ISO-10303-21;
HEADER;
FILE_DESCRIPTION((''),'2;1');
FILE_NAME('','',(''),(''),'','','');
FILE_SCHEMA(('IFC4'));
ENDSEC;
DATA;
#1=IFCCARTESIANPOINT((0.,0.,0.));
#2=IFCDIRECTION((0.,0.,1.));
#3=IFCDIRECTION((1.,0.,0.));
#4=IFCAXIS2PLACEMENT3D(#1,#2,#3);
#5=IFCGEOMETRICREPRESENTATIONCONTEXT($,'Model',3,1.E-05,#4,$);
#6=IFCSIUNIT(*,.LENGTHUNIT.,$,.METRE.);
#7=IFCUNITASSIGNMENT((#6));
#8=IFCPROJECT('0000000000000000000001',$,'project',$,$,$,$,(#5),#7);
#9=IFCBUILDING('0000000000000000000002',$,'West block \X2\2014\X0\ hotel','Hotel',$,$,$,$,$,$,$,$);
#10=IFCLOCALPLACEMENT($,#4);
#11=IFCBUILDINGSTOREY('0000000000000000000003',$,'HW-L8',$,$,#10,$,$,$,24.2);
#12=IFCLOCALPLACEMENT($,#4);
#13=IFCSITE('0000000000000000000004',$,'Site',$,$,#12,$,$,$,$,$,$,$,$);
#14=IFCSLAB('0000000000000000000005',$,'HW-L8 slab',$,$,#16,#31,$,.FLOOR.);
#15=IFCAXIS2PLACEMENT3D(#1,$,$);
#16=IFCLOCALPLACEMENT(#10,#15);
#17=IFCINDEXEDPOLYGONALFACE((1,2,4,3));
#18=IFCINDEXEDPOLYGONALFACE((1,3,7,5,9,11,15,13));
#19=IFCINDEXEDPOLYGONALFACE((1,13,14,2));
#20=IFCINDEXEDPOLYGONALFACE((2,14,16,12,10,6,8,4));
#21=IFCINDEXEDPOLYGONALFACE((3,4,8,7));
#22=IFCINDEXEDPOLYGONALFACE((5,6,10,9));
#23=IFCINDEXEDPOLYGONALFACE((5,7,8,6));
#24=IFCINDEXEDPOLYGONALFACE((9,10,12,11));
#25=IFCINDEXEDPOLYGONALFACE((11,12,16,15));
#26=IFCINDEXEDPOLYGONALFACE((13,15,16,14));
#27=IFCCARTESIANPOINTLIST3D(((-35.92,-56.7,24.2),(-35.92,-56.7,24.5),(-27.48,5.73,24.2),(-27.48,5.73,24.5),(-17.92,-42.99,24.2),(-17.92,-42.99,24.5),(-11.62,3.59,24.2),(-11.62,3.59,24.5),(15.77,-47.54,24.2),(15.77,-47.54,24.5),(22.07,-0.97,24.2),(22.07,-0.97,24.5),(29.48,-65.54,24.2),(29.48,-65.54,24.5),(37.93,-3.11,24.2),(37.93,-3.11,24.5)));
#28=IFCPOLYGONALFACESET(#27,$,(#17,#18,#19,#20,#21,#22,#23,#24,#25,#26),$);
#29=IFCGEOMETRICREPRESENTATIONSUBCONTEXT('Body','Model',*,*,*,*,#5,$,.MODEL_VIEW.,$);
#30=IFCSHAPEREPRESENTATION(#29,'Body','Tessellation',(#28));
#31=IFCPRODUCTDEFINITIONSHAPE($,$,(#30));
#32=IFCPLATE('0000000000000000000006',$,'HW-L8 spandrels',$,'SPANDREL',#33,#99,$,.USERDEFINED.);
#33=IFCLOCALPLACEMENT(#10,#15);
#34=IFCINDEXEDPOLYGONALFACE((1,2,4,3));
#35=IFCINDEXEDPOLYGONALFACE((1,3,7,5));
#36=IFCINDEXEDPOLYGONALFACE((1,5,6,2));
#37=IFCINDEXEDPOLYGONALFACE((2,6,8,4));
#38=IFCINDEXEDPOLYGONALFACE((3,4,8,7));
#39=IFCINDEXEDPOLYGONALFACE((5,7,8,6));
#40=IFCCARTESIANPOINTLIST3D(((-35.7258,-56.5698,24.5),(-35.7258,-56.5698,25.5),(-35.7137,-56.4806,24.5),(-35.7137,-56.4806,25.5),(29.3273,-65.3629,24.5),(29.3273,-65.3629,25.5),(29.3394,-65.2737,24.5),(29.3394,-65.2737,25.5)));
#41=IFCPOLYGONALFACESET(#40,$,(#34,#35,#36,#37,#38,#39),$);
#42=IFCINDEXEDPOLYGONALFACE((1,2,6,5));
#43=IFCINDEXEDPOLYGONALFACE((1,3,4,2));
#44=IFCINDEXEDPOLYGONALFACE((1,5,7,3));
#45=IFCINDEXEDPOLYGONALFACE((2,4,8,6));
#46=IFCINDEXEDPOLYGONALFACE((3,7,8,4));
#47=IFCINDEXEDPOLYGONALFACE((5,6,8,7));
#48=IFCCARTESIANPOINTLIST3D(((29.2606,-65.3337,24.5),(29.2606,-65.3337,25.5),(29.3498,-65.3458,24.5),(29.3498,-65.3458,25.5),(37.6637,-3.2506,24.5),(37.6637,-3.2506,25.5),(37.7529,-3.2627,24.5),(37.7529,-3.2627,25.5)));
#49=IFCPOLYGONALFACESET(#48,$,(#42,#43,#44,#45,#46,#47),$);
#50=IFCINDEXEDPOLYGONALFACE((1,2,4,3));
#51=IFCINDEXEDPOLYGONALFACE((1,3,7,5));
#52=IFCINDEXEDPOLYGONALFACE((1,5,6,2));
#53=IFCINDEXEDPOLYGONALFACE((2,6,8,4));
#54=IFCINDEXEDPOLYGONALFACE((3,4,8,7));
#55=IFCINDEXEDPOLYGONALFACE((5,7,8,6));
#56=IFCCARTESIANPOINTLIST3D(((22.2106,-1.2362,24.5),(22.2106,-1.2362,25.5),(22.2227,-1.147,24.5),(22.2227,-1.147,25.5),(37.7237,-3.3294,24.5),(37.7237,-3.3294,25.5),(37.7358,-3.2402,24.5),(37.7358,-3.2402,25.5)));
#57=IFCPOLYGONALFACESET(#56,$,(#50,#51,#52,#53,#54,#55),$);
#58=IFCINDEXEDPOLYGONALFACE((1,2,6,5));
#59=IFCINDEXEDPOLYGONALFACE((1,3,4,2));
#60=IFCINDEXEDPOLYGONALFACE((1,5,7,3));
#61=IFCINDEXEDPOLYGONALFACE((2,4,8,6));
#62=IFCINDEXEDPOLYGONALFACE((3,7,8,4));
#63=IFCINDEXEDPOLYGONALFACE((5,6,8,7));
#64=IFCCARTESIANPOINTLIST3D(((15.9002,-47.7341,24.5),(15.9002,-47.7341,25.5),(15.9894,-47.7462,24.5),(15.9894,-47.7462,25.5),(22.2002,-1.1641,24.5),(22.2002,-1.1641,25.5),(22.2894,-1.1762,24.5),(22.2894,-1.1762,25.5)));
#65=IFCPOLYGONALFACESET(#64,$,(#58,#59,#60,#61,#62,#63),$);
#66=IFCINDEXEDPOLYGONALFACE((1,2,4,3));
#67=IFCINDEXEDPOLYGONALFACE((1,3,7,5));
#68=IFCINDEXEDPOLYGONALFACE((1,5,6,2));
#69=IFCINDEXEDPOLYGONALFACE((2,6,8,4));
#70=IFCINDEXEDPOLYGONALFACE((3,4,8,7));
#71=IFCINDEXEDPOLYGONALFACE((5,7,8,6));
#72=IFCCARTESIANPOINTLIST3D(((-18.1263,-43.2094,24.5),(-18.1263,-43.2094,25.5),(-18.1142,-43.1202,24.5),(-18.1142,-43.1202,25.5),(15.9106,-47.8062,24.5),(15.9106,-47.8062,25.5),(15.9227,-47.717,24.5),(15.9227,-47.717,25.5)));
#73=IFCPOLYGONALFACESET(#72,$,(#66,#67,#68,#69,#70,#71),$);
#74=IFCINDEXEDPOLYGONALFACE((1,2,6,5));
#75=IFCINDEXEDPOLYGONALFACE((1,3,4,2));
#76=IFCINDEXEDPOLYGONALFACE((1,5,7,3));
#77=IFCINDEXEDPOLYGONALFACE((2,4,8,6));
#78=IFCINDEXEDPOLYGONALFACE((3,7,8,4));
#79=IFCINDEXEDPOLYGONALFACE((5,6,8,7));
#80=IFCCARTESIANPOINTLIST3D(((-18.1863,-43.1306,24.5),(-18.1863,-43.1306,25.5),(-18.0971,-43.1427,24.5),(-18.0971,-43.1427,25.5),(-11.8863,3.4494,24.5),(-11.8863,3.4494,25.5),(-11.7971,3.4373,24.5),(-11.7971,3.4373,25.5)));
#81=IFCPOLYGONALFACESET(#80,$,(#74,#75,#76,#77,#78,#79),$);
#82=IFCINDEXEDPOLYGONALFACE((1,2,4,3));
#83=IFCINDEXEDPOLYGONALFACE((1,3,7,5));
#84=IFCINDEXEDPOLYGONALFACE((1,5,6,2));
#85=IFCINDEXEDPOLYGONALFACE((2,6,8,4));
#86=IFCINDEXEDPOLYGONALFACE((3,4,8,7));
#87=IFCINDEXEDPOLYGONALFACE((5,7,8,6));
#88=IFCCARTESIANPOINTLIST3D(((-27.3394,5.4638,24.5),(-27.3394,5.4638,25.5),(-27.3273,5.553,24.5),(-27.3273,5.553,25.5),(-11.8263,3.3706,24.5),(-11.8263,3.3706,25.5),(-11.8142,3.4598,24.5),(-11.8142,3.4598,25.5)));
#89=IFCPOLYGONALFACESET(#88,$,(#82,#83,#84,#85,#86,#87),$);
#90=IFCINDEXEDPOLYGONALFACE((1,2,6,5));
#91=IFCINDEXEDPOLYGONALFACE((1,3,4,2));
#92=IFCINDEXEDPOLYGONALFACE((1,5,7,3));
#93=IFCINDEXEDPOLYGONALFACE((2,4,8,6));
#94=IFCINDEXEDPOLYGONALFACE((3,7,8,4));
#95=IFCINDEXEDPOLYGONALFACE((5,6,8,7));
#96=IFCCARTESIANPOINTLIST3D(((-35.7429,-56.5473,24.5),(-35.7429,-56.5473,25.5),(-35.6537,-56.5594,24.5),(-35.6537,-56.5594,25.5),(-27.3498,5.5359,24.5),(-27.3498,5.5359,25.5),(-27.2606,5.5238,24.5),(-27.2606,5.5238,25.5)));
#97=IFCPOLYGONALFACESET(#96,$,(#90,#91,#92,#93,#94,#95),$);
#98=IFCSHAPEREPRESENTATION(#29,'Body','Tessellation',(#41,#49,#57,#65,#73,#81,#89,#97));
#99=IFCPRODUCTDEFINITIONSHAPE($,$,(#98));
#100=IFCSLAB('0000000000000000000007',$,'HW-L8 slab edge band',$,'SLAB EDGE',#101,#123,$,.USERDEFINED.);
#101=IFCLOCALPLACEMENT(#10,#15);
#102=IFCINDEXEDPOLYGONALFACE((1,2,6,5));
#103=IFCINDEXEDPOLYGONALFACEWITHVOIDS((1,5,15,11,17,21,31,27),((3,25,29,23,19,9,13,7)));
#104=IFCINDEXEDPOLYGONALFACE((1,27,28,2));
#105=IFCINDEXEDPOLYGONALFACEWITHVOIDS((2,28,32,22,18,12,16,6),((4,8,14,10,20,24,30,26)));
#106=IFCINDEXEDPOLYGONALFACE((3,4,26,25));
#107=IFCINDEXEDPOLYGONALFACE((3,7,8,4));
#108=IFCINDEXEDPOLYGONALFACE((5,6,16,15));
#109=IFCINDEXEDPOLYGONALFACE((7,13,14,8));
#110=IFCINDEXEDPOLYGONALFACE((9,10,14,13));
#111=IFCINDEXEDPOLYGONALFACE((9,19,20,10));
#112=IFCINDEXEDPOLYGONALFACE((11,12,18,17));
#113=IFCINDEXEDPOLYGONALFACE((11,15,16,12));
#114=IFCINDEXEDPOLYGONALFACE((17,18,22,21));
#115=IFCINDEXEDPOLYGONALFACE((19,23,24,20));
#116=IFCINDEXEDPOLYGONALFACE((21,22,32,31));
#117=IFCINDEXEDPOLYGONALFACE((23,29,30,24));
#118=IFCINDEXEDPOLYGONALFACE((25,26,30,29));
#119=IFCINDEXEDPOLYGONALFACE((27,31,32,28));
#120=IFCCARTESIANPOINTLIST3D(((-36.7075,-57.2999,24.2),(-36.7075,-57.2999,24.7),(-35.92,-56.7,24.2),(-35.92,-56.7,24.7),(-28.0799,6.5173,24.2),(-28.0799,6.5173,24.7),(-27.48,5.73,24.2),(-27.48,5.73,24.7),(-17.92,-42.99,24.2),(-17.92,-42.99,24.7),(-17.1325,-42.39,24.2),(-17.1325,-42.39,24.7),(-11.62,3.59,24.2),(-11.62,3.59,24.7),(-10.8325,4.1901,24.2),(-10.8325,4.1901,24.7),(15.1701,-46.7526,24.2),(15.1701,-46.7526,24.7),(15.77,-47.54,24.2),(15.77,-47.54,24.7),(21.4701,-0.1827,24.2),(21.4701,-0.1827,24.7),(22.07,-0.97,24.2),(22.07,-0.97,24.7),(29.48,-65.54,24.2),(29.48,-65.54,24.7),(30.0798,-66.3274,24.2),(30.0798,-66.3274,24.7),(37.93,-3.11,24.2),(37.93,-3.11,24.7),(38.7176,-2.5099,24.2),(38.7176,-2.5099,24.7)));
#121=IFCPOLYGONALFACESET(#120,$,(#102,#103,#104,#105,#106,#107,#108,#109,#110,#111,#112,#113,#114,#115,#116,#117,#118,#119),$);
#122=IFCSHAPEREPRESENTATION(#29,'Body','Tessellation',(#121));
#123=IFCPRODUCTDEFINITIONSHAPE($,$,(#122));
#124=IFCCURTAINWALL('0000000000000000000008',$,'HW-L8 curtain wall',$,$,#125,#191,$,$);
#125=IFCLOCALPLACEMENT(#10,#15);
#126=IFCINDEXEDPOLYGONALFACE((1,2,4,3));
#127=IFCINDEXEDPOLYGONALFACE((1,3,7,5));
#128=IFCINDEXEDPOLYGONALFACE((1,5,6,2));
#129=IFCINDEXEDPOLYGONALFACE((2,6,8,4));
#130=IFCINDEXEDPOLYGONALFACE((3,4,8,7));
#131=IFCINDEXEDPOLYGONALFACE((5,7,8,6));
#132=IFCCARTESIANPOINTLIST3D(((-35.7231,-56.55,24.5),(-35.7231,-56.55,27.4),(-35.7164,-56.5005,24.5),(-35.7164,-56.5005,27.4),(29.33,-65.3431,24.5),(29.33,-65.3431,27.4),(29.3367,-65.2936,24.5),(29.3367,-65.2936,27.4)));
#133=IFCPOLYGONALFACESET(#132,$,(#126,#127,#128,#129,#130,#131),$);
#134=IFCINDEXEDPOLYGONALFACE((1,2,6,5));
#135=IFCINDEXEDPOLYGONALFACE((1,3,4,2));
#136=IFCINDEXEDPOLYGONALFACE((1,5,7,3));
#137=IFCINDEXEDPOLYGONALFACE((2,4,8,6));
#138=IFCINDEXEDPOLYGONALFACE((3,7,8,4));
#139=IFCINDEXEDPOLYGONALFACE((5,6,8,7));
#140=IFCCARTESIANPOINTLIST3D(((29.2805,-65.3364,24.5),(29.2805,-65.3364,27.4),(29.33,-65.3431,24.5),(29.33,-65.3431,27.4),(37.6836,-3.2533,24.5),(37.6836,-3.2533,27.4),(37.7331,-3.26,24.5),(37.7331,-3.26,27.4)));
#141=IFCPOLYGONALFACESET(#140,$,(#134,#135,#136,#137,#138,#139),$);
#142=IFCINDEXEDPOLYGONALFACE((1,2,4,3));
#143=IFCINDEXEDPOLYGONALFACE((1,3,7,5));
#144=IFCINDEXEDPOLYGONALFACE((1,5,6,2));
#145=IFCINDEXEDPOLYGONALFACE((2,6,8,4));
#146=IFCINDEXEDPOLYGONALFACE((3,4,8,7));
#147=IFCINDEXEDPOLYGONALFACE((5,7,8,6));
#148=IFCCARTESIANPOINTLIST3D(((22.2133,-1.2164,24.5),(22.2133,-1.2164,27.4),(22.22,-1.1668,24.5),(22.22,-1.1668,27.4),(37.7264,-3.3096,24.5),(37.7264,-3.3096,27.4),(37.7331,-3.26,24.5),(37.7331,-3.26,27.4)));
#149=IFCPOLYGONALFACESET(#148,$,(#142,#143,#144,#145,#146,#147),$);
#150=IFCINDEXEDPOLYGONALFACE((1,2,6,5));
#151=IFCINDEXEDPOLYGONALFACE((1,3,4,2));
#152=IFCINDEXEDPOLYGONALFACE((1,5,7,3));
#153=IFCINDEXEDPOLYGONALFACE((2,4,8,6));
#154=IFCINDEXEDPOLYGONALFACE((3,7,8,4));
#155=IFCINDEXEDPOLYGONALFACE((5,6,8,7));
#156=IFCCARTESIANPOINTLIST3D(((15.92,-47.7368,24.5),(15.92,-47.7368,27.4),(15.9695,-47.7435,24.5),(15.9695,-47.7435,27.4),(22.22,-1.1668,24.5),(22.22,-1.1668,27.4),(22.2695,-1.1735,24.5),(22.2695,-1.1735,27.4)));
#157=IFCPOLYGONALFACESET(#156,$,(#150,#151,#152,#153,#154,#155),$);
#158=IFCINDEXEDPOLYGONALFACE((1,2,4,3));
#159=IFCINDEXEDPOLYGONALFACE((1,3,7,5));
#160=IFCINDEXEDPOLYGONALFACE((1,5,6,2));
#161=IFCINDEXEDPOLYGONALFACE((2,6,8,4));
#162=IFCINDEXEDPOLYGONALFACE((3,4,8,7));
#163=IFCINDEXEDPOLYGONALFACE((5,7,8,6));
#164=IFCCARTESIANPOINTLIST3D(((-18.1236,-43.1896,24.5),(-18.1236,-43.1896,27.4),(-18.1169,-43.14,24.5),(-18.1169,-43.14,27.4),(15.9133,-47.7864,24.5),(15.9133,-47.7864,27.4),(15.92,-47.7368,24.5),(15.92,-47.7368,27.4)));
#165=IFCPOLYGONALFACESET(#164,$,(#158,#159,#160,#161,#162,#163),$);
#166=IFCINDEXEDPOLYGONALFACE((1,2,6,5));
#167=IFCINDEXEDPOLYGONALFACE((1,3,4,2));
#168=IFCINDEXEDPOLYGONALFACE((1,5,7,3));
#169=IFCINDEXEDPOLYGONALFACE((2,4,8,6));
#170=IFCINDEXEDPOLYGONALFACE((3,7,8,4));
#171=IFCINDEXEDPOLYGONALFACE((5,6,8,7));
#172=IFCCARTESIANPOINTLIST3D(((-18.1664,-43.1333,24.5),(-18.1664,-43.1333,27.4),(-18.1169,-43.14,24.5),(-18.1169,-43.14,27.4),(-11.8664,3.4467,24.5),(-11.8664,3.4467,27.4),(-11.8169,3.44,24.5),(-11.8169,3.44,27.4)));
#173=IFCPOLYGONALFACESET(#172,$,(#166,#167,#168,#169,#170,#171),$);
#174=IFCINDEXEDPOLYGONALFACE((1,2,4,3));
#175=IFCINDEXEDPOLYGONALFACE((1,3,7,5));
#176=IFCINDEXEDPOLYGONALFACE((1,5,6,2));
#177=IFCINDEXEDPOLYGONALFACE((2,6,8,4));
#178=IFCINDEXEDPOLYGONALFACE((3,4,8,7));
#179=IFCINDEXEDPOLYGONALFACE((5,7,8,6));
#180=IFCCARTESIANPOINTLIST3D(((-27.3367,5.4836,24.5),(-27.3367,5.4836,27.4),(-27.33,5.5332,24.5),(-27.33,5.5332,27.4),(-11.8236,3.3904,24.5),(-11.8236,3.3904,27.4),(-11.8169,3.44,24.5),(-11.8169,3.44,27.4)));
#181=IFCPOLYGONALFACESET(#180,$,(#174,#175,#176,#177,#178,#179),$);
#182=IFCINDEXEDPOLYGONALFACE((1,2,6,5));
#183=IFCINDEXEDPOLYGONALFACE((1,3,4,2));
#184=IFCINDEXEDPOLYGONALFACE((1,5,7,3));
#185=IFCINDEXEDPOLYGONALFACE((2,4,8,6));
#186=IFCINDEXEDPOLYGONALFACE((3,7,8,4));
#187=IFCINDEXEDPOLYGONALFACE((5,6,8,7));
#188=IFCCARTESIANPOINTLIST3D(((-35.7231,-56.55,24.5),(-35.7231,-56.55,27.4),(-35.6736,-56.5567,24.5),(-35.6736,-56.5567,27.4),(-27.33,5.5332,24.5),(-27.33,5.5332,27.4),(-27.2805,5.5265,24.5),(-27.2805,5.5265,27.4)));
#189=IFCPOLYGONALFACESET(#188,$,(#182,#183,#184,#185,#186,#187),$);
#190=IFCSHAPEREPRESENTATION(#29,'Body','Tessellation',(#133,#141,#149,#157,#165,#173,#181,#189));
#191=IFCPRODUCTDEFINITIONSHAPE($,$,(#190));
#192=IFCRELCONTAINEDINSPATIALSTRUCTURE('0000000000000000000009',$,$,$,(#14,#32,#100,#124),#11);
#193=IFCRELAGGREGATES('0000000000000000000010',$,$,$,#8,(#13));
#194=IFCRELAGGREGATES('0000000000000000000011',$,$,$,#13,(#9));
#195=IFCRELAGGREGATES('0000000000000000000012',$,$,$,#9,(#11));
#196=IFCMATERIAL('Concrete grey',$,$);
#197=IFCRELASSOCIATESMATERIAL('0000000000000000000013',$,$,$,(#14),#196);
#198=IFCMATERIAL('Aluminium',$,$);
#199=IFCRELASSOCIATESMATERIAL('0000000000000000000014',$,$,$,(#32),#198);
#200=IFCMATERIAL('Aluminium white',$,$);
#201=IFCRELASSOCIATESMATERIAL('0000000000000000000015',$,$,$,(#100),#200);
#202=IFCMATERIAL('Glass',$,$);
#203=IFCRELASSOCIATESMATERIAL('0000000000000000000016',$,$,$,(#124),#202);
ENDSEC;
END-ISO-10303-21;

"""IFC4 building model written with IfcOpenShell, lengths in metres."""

from ifc_helpers import new_model, si_unit, frame, origin_with_axes, place, context, subcontext, project, spatial, polyline, outline, extrude, material, element, save


model = new_model("IFC4")

# Units and contexts
model_context = context("Model", 3, precision=1e-05, world=origin_with_axes())
body_context = subcontext(model_context, "Body", "Model", "MODEL_VIEW")
ifc_project = project(units=[si_unit("LENGTHUNIT", "METRE")], contexts=[model_context])

# Site, building, storey
site_placement = place(None, origin_with_axes())
site = spatial("IfcSite", under=ifc_project, at=site_placement, Name="Site")
building = spatial("IfcBuilding", under=site, Name="West block — hotel", Description="Hotel")
storey_placement = place(None, origin_with_axes())
storey = spatial("IfcBuildingStorey", under=building, at=storey_placement, Name="HW-L8", Elevation=24.2)

# Shared definitions
ifc_material_1 = material(Name="Aluminium")

# Slab
ifc_material_2 = material(Name="Concrete grey")
slab_1_placement = place(storey_placement, origin_with_axes())
element("IfcSlab", 1, at=slab_1_placement, inside=storey, material=ifc_material_2, Name="HW-L8 slab", PredefinedType="FLOOR", context=body_context, shape_type="SweptSolid", body=[
    extrude(outline(polyline([(-35.92, -56.7), (29.48, -65.54), (37.93, -3.11), (22.07, -0.97), (15.77, -47.54), (-17.92, -42.99), (-11.62, 3.59), (-27.48, 5.73), (-35.92, -56.7)])), frame((0.0, 0.0, 24.2), z_axis=(0.0, 0.0, 1.0), x_axis=(1.0, 0.0, 0.0)), (0.0, 0.0, 1.0), 0.3),
])

# Plate
plate_placement = place(storey_placement, origin_with_axes())
element("IfcPlate", 2, at=plate_placement, inside=storey, material=ifc_material_1, Name="HW-L8 spandrels", ObjectType="SPANDREL", PredefinedType="USERDEFINED", context=body_context, shape_type="SweptSolid", body=[
    extrude(outline(polyline([(-35.7258, -56.5698), (29.3273, -65.3629), (29.3394, -65.2737), (-35.7137, -56.4806), (-35.7258, -56.5698)])), frame((0.0, 0.0, 24.5), z_axis=(0.0, 0.0, 1.0), x_axis=(1.0, 0.0, 0.0)), (0.0, 0.0, 1.0), 1.0),
    extrude(outline(polyline([(29.3498, -65.3458), (37.7529, -3.2627), (37.6637, -3.2506), (29.2606, -65.3337), (29.3498, -65.3458)])), frame((0.0, 0.0, 24.5), z_axis=(0.0, 0.0, 1.0), x_axis=(1.0, 0.0, 0.0)), (0.0, 0.0, 1.0), 1.0),
    extrude(outline(polyline([(37.7358, -3.2402), (22.2227, -1.147), (22.2106, -1.2362), (37.7237, -3.3294), (37.7358, -3.2402)])), frame((0.0, 0.0, 24.5), z_axis=(0.0, 0.0, 1.0), x_axis=(1.0, 0.0, 0.0)), (0.0, 0.0, 1.0), 1.0),
    extrude(outline(polyline([(22.2002, -1.1641), (15.9002, -47.7341), (15.9894, -47.7462), (22.2894, -1.1762), (22.2002, -1.1641)])), frame((0.0, 0.0, 24.5), z_axis=(0.0, 0.0, 1.0), x_axis=(1.0, 0.0, 0.0)), (0.0, 0.0, 1.0), 1.0),
    extrude(outline(polyline([(15.9227, -47.717), (-18.1142, -43.1202), (-18.1263, -43.2094), (15.9106, -47.8062), (15.9227, -47.717)])), frame((0.0, 0.0, 24.5), z_axis=(0.0, 0.0, 1.0), x_axis=(1.0, 0.0, 0.0)), (0.0, 0.0, 1.0), 1.0),
    extrude(outline(polyline([(-18.0971, -43.1427), (-11.7971, 3.4373), (-11.8863, 3.4494), (-18.1863, -43.1306), (-18.0971, -43.1427)])), frame((0.0, 0.0, 24.5), z_axis=(0.0, 0.0, 1.0), x_axis=(1.0, 0.0, 0.0)), (0.0, 0.0, 1.0), 1.0),
    extrude(outline(polyline([(-11.8142, 3.4598), (-27.3273, 5.553), (-27.3394, 5.4638), (-11.8263, 3.3706), (-11.8142, 3.4598)])), frame((0.0, 0.0, 24.5), z_axis=(0.0, 0.0, 1.0), x_axis=(1.0, 0.0, 0.0)), (0.0, 0.0, 1.0), 1.0),
    extrude(outline(polyline([(-27.3498, 5.5359), (-35.7429, -56.5473), (-35.6537, -56.5594), (-27.2606, 5.5238), (-27.3498, 5.5359)])), frame((0.0, 0.0, 24.5), z_axis=(0.0, 0.0, 1.0), x_axis=(1.0, 0.0, 0.0)), (0.0, 0.0, 1.0), 1.0),
])

# Slab
ifc_material_3 = material(Name="Aluminium white")
slab_2_placement = place(storey_placement, origin_with_axes())
element("IfcSlab", 3, at=slab_2_placement, inside=storey, material=ifc_material_3, Name="HW-L8 slab edge band", ObjectType="SLAB EDGE", PredefinedType="USERDEFINED", context=body_context, shape_type="SweptSolid", body=[
    extrude(outline(polyline([(-36.7075, -57.2999), (30.0798, -66.3274), (38.7176, -2.5099), (21.4701, -0.1827), (15.1701, -46.7526), (-17.1325, -42.39), (-10.8325, 4.1901), (-28.0799, 6.5173), (-36.7075, -57.2999)]), holes=[polyline([(-35.92, -56.7), (29.48, -65.54), (37.93, -3.11), (22.07, -0.97), (15.77, -47.54), (-17.92, -42.99), (-11.62, 3.59), (-27.48, 5.73), (-35.92, -56.7)])]), frame((0.0, 0.0, 24.2), z_axis=(0.0, 0.0, 1.0), x_axis=(1.0, 0.0, 0.0)), (0.0, 0.0, 1.0), 0.5),
])

# Curtain wall
ifc_material_4 = material(Name="Glass")
curtain_wall_placement = place(storey_placement, origin_with_axes())
element("IfcCurtainWall", 4, at=curtain_wall_placement, inside=storey, material=ifc_material_4, Name="HW-L8 curtain wall", context=body_context, shape_type="SweptSolid", body=[
    extrude(outline(polyline([(-35.7231, -56.55), (29.33, -65.3431), (29.3367, -65.2936), (-35.7164, -56.5005), (-35.7231, -56.55)])), frame((0.0, 0.0, 24.5), z_axis=(0.0, 0.0, 1.0), x_axis=(1.0, 0.0, 0.0)), (0.0, 0.0, 1.0), 2.9),
    extrude(outline(polyline([(29.33, -65.3431), (37.7331, -3.26), (37.6836, -3.2533), (29.2805, -65.3364), (29.33, -65.3431)])), frame((0.0, 0.0, 24.5), z_axis=(0.0, 0.0, 1.0), x_axis=(1.0, 0.0, 0.0)), (0.0, 0.0, 1.0), 2.9),
    extrude(outline(polyline([(37.7331, -3.26), (22.22, -1.1668), (22.2133, -1.2164), (37.7264, -3.3096), (37.7331, -3.26)])), frame((0.0, 0.0, 24.5), z_axis=(0.0, 0.0, 1.0), x_axis=(1.0, 0.0, 0.0)), (0.0, 0.0, 1.0), 2.9),
    extrude(outline(polyline([(22.22, -1.1668), (15.92, -47.7368), (15.9695, -47.7435), (22.2695, -1.1735), (22.22, -1.1668)])), frame((0.0, 0.0, 24.5), z_axis=(0.0, 0.0, 1.0), x_axis=(1.0, 0.0, 0.0)), (0.0, 0.0, 1.0), 2.9),
    extrude(outline(polyline([(15.92, -47.7368), (-18.1169, -43.14), (-18.1236, -43.1896), (15.9133, -47.7864), (15.92, -47.7368)])), frame((0.0, 0.0, 24.5), z_axis=(0.0, 0.0, 1.0), x_axis=(1.0, 0.0, 0.0)), (0.0, 0.0, 1.0), 2.9),
    extrude(outline(polyline([(-18.1169, -43.14), (-11.8169, 3.44), (-11.8664, 3.4467), (-18.1664, -43.1333), (-18.1169, -43.14)])), frame((0.0, 0.0, 24.5), z_axis=(0.0, 0.0, 1.0), x_axis=(1.0, 0.0, 0.0)), (0.0, 0.0, 1.0), 2.9),
    extrude(outline(polyline([(-11.8169, 3.44), (-27.33, 5.5332), (-27.3367, 5.4836), (-11.8236, 3.3904), (-11.8169, 3.44)])), frame((0.0, 0.0, 24.5), z_axis=(0.0, 0.0, 1.0), x_axis=(1.0, 0.0, 0.0)), (0.0, 0.0, 1.0), 2.9),
    extrude(outline(polyline([(-27.33, 5.5332), (-35.7231, -56.55), (-35.6736, -56.5567), (-27.2805, 5.5265), (-27.33, 5.5332)])), frame((0.0, 0.0, 24.5), z_axis=(0.0, 0.0, 1.0), x_axis=(1.0, 0.0, 0.0)), (0.0, 0.0, 1.0), 2.9),
])

save(model, "model.ifc")
